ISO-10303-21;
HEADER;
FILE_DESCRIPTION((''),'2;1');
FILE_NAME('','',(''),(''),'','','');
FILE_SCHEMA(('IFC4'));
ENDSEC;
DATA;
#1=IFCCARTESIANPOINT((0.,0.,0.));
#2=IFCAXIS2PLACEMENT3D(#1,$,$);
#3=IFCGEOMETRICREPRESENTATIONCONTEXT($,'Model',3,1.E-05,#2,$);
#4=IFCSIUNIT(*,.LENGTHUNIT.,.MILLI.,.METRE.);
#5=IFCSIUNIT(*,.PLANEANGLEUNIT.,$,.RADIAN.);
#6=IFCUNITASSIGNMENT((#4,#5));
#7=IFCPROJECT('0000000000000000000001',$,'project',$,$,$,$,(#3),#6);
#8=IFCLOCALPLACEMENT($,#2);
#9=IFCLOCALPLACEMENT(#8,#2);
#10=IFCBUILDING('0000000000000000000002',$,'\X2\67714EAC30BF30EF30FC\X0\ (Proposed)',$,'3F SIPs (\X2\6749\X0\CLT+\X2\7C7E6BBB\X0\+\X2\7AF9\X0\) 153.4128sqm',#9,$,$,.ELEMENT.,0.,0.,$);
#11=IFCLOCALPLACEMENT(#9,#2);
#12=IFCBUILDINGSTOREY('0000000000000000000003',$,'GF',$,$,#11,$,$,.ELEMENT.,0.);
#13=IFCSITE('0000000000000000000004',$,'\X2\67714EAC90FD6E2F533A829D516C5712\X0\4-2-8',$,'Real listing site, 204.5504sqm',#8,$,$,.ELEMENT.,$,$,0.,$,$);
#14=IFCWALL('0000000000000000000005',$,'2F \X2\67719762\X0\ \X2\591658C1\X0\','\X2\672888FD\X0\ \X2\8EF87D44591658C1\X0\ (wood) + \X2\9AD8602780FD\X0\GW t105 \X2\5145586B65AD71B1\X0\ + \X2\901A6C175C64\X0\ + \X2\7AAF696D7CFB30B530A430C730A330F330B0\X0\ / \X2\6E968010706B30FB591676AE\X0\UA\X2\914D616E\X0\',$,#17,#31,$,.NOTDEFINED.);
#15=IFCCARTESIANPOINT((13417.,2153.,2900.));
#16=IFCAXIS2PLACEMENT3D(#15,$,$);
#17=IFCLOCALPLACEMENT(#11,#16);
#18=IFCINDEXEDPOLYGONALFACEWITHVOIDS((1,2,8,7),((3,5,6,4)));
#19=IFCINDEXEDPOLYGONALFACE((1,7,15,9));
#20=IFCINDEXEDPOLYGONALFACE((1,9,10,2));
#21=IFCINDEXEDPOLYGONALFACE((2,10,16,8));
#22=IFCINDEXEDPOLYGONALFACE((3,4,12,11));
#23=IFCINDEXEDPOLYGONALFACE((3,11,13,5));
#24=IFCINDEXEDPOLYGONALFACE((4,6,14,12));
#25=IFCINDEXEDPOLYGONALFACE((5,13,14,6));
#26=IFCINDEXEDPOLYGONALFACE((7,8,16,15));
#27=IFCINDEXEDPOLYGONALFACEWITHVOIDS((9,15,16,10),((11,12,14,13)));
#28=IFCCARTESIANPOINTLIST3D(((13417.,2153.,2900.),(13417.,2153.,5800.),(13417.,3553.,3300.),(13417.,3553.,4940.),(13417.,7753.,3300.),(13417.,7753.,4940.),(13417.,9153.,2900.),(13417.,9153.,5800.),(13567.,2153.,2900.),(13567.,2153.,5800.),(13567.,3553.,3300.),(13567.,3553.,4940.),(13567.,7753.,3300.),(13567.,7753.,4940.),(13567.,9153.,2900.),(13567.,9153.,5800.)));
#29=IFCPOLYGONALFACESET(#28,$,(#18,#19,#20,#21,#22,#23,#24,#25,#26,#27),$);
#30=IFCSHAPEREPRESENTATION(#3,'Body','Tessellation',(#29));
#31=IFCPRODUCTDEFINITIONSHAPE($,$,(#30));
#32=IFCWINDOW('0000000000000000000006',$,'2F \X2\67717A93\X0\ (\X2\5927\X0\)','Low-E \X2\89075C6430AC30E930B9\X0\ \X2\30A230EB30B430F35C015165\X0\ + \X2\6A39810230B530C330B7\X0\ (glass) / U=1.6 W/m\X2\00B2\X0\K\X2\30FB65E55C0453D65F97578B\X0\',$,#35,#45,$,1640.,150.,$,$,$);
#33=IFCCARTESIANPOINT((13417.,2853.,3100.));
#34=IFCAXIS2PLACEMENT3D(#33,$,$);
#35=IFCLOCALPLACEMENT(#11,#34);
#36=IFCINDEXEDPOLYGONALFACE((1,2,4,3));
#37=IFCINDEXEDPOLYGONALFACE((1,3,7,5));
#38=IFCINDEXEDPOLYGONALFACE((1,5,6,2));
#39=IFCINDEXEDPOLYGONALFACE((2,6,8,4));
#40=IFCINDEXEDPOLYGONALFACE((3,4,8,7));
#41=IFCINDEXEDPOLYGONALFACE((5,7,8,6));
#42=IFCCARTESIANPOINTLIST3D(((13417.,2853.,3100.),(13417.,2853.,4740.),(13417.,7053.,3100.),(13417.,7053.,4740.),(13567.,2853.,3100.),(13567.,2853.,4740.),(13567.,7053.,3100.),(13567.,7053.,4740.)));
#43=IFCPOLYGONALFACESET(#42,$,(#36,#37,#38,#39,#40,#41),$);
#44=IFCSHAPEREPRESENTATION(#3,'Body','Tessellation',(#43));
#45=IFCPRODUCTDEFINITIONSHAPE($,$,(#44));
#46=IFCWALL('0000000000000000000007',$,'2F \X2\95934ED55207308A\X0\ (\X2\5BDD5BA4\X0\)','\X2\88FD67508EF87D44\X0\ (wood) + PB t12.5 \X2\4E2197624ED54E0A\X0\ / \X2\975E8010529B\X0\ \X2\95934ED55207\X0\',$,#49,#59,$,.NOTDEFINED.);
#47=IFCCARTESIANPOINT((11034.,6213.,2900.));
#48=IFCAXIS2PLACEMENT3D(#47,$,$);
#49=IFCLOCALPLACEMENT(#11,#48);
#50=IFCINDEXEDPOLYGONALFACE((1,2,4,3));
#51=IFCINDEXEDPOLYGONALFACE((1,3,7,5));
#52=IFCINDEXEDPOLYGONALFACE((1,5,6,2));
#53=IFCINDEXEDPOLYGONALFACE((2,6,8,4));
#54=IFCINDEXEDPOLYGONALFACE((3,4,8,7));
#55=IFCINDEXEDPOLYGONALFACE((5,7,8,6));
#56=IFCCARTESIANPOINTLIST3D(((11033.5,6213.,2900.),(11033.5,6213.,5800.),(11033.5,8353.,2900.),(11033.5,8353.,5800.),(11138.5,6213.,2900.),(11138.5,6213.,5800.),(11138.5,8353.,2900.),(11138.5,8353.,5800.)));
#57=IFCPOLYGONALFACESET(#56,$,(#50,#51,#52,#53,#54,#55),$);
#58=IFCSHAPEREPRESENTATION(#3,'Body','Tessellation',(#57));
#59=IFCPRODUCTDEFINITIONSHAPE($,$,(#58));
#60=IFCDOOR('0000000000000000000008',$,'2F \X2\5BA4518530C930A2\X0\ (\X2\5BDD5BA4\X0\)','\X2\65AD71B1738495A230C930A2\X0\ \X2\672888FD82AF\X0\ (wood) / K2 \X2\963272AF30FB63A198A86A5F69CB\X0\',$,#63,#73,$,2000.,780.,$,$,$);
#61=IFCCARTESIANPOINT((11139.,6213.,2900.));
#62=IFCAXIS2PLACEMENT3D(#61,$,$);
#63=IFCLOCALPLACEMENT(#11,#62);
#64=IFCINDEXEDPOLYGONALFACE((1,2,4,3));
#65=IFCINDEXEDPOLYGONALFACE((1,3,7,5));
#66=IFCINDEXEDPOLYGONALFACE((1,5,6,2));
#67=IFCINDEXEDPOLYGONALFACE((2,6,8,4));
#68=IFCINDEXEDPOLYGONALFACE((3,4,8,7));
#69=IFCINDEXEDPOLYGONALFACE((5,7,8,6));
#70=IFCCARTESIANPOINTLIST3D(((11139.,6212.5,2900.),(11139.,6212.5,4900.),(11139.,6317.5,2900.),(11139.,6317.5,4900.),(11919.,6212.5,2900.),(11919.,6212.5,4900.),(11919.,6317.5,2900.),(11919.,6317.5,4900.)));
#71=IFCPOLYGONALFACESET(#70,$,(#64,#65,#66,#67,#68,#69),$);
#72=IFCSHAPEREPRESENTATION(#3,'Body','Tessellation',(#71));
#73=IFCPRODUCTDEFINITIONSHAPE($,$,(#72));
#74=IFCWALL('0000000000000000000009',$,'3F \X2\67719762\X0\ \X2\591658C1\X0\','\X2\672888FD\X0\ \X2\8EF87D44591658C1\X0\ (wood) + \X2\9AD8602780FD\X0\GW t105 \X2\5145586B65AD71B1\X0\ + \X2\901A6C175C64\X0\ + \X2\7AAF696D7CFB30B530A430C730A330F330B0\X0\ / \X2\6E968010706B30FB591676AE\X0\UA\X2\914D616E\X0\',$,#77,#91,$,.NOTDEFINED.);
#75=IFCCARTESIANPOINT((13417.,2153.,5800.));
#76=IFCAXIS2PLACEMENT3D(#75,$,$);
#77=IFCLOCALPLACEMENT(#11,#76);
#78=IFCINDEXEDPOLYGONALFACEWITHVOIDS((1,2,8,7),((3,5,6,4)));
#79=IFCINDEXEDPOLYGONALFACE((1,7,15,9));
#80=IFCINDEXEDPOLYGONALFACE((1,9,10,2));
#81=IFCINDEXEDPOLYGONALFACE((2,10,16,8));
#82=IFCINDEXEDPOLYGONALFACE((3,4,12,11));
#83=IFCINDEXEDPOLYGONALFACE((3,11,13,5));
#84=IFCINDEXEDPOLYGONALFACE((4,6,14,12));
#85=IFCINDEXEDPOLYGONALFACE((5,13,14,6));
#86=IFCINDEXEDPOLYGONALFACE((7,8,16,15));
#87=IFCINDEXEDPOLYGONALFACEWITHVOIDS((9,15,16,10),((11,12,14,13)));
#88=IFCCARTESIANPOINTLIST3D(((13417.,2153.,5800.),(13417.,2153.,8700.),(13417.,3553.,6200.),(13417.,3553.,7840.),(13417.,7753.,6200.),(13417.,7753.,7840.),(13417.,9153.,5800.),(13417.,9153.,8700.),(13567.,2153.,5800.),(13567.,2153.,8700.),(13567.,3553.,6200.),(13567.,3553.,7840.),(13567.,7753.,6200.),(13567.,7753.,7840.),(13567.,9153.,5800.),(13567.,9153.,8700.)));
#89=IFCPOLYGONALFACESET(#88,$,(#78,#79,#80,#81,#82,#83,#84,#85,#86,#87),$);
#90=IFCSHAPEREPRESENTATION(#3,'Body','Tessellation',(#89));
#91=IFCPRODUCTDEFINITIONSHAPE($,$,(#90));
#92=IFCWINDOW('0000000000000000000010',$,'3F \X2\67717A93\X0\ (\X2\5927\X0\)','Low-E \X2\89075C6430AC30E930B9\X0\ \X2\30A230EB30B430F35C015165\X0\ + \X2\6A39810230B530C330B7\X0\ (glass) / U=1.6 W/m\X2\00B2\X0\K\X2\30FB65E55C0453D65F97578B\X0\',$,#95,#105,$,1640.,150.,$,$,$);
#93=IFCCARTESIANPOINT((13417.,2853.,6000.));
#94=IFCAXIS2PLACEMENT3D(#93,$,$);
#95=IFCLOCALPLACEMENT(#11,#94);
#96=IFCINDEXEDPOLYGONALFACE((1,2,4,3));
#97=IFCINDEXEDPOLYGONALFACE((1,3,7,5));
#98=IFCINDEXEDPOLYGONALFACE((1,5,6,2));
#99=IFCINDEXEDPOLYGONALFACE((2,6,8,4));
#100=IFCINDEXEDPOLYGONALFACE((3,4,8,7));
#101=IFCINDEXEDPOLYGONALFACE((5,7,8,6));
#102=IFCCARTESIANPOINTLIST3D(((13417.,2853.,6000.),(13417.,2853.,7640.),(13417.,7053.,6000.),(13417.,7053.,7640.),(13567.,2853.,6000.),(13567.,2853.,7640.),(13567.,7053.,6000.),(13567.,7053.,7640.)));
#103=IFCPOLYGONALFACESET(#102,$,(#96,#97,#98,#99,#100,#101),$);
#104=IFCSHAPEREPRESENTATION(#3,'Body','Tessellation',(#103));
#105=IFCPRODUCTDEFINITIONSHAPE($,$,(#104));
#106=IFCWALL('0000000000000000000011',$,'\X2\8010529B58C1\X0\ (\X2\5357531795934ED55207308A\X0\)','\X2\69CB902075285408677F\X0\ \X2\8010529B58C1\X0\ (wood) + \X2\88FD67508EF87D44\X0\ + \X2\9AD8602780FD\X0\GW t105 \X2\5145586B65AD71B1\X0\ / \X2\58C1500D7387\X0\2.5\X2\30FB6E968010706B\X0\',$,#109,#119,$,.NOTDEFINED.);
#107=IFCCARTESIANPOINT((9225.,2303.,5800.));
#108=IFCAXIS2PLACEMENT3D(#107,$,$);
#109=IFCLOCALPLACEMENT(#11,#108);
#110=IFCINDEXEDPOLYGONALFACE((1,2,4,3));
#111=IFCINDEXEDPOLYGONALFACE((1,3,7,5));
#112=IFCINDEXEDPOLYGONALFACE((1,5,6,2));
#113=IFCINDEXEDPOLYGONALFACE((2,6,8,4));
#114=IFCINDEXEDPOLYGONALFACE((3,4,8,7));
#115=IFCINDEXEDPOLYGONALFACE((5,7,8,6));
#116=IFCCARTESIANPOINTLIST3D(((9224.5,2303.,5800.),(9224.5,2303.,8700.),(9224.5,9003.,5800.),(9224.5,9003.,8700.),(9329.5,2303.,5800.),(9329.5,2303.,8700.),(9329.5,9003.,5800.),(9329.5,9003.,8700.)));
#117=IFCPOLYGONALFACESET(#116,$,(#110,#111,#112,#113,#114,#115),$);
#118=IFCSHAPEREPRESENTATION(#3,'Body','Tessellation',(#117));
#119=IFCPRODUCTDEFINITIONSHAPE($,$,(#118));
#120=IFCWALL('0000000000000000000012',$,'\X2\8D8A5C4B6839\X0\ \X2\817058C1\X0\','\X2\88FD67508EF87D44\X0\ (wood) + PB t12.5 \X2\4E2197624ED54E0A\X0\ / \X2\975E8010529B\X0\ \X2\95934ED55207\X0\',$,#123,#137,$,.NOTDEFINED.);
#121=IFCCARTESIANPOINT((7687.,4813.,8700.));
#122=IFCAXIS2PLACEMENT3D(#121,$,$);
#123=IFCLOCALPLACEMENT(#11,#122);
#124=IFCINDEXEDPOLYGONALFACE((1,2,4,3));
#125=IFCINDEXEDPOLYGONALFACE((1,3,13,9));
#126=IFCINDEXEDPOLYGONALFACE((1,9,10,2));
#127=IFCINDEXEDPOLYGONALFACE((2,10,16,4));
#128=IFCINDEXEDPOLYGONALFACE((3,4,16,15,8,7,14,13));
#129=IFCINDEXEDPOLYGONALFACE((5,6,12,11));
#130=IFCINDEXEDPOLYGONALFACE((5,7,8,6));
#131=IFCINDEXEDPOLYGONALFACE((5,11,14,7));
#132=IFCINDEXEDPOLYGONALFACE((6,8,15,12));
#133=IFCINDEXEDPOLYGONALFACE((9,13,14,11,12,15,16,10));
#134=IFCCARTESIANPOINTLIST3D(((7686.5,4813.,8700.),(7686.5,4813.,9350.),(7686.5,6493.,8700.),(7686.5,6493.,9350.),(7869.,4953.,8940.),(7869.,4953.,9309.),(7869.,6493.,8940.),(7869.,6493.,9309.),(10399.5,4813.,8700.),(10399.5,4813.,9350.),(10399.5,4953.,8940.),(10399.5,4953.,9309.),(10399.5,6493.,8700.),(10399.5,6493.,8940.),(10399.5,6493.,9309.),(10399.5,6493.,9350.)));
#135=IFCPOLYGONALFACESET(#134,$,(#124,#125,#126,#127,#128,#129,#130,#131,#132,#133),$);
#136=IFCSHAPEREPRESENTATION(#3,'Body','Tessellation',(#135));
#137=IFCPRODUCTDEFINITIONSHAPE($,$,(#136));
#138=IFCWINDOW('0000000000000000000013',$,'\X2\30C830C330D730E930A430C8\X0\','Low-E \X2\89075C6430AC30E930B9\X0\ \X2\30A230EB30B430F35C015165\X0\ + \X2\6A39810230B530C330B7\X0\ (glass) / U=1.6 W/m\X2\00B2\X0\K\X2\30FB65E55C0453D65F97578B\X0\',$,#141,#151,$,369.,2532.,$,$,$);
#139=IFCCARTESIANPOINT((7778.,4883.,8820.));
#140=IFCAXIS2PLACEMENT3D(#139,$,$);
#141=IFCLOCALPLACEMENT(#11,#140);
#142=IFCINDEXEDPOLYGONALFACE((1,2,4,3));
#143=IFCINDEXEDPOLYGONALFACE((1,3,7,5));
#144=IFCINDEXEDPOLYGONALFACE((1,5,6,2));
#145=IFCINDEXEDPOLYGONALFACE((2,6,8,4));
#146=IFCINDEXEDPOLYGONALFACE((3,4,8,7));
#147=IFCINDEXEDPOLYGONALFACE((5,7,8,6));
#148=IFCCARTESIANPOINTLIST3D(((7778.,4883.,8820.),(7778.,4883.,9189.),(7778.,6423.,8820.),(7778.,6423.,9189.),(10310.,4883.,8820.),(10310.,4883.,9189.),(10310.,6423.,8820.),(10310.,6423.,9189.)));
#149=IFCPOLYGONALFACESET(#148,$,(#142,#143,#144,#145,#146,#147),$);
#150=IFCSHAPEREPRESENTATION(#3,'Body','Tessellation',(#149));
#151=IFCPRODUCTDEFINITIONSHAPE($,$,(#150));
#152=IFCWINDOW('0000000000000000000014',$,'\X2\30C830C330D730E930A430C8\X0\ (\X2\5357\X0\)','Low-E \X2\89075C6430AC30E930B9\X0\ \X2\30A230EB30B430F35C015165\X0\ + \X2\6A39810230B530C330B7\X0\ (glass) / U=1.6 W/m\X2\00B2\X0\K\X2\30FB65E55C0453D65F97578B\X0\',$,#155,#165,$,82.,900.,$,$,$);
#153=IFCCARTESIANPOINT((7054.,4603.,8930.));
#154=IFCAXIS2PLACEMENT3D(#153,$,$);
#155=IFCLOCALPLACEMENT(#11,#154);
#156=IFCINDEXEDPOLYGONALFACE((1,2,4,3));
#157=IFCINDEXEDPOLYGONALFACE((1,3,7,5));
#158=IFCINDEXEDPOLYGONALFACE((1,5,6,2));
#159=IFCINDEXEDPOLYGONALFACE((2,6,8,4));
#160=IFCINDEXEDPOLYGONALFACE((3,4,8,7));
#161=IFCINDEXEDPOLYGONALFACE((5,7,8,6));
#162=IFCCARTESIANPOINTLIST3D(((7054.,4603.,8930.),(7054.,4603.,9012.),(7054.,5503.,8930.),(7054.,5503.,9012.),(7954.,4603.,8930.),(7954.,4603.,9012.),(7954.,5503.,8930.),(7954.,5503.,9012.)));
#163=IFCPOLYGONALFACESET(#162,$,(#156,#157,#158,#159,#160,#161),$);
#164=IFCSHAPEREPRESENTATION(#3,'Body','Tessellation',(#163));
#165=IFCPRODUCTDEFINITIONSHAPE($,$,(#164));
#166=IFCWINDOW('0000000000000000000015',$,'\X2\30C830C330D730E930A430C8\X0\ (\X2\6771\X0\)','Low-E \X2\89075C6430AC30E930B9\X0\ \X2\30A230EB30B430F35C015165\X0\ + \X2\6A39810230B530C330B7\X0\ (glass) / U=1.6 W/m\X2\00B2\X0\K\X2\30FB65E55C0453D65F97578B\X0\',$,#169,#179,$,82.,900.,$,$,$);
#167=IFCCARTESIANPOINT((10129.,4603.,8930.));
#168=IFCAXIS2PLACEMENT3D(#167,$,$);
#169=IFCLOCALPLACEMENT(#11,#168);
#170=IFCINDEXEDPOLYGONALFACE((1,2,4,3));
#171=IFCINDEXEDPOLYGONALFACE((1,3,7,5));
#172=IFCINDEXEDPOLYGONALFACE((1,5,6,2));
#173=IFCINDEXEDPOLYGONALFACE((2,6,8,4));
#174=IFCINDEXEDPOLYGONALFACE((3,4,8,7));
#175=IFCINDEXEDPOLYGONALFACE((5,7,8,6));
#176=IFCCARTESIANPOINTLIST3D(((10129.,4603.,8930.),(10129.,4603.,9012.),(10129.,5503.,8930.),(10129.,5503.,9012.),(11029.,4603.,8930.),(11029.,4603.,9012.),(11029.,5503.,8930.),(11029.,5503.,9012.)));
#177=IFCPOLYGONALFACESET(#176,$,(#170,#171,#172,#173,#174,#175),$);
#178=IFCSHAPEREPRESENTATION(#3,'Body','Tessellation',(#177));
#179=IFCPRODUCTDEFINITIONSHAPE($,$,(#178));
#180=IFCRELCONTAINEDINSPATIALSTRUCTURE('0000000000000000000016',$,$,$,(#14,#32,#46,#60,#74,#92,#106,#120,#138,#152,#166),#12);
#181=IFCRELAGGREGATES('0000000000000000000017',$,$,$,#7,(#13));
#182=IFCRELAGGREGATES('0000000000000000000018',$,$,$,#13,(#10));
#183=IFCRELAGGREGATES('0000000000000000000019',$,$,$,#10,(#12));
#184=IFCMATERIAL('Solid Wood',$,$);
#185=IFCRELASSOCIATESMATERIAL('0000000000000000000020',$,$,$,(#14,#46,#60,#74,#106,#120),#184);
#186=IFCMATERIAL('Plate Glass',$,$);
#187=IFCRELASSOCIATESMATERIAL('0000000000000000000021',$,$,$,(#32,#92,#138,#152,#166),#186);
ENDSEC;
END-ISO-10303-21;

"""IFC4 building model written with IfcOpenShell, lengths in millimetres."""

from ifc_helpers import new_model, si_unit, frame, frame_2d, origin, place, context, project, spatial, rectangle, extrude, material, element, fill, save


model = new_model("IFC4")

# Units and contexts
model_context = context("Model", 3, precision=1e-05, world=origin())
ifc_project = project(units=[si_unit("LENGTHUNIT", "METRE", prefix="MILLI"), si_unit("PLANEANGLEUNIT", "RADIAN")], contexts=[model_context])

# Site, building, storey
site_placement = place(None, origin())
site = spatial("IfcSite", under=ifc_project, at=site_placement, Name="東京都港区芝公園4-2-8", ObjectType="Real listing site, 204.5504sqm", CompositionType="ELEMENT", RefElevation=0.0)
building_placement = place(site_placement, origin())
building = spatial("IfcBuilding", under=site, at=building_placement, Name="東京タワー (Proposed)", ObjectType="3F SIPs (杉CLT+籾殻+竹) 153.4128sqm", CompositionType="ELEMENT", ElevationOfRefHeight=0.0, ElevationOfTerrain=0.0)
storey_placement = place(building_placement, origin())
storey = spatial("IfcBuildingStorey", under=building, at=storey_placement, Name="GF", CompositionType="ELEMENT", Elevation=0.0)

# Wall, opening, window
ifc_material_1 = material(Name="Solid Wood")
wall_1_placement = place(storey_placement, frame((13417.0, 2153.0, 2900.0)))
wall_1 = element("IfcWall", 1, at=wall_1_placement, inside=storey, material=ifc_material_1, Name="2F 東面 外壁", Description="木製 軸組外壁 (wood) + 高性能GW t105 充填断熱 + 通気層 + 窯業系サイディング / 準耐火・外皮UA配慮", PredefinedType="NOTDEFINED", context=model_context, shape_type="SweptSolid", body=[
    extrude(rectangle(XDim=150.0, YDim=7000.0, at=frame_2d((75.0, 3500.0))), frame((13417.0, 2153.0, 2900.0)), (0.0, 0.0, 1.0), 2900.0),
])
opening_1_placement = place(storey_placement, frame((13417.0, 2853.0, 3100.0)))
opening_1 = element("IfcOpeningElement", 2, at=opening_1_placement, cuts=wall_1, PredefinedType="NOTDEFINED", context=model_context, shape_type="SweptSolid", body=[
    extrude(rectangle(XDim=150.0, YDim=4200.0, at=frame_2d((75.0, 2100.0))), frame((13417.0, 2853.0, 3100.0)), (0.0, 0.0, 1.0), 1640.0),
])
ifc_material_2 = material(Name="Plate Glass")
window_1_placement = place(storey_placement, frame((13417.0, 2853.0, 3100.0)))
window_1 = element("IfcWindow", 3, at=window_1_placement, inside=storey, material=ifc_material_2, Name="2F 東窓 (大)", Description="Low-E 複層ガラス アルゴン封入 + 樹脂サッシ (glass) / U=1.6 W/m²K・日射取得型", OverallHeight=1640.0, OverallWidth=150.0, context=model_context, shape_type="SweptSolid", body=[
    extrude(rectangle(XDim=150.0, YDim=4200.0, at=frame_2d((75.0, 2100.0))), frame((13417.0, 2853.0, 3100.0)), (0.0, 0.0, 1.0), 1640.0),
])
fill(opening_1, window_1)

# Wall
wall_2_placement = place(storey_placement, frame((11034.0, 6213.0, 2900.0)))
element("IfcWall", 4, at=wall_2_placement, inside=storey, material=ifc_material_1, Name="2F 間仕切り (寝室)", Description="製材軸組 (wood) + PB t12.5 両面仕上 / 非耐力 間仕切", PredefinedType="NOTDEFINED", context=model_context, shape_type="SweptSolid", body=[
    extrude(rectangle(XDim=105.0, YDim=2140.0, at=frame_2d((52.0, 1070.0))), frame((11034.0, 6213.0, 2900.0)), (0.0, 0.0, 1.0), 2900.0),
])

# Door
door_1_placement = place(storey_placement, frame((11139.0, 6213.0, 2900.0)))
element("IfcDoor", 5, at=door_1_placement, inside=storey, material=ifc_material_1, Name="2F 室内ドア (寝室)", Description="断熱玄関ドア 木製芯 (wood) / K2 防犯・採風機構", OverallHeight=2000.0, OverallWidth=780.0, context=model_context, shape_type="SweptSolid", body=[
    extrude(rectangle(XDim=780.0, YDim=105.0, at=frame_2d((390.0, 52.0))), frame((11139.0, 6213.0, 2900.0)), (0.0, 0.0, 1.0), 2000.0),
])

# Wall, opening, window
wall_3_placement = place(storey_placement, frame((13417.0, 2153.0, 5800.0)))
wall_3 = element("IfcWall", 6, at=wall_3_placement, inside=storey, material=ifc_material_1, Name="3F 東面 外壁", Description="木製 軸組外壁 (wood) + 高性能GW t105 充填断熱 + 通気層 + 窯業系サイディング / 準耐火・外皮UA配慮", PredefinedType="NOTDEFINED", context=model_context, shape_type="SweptSolid", body=[
    extrude(rectangle(XDim=150.0, YDim=7000.0, at=frame_2d((75.0, 3500.0))), frame((13417.0, 2153.0, 5800.0)), (0.0, 0.0, 1.0), 2900.0),
])
opening_2_placement = place(storey_placement, frame((13417.0, 2853.0, 6000.0)))
opening_2 = element("IfcOpeningElement", 7, at=opening_2_placement, cuts=wall_3, PredefinedType="NOTDEFINED", context=model_context, shape_type="SweptSolid", body=[
    extrude(rectangle(XDim=150.0, YDim=4200.0, at=frame_2d((75.0, 2100.0))), frame((13417.0, 2853.0, 6000.0)), (0.0, 0.0, 1.0), 1640.0),
])
window_2_placement = place(storey_placement, frame((13417.0, 2853.0, 6000.0)))
window_2 = element("IfcWindow", 8, at=window_2_placement, inside=storey, material=ifc_material_2, Name="3F 東窓 (大)", Description="Low-E 複層ガラス アルゴン封入 + 樹脂サッシ (glass) / U=1.6 W/m²K・日射取得型", OverallHeight=1640.0, OverallWidth=150.0, context=model_context, shape_type="SweptSolid", body=[
    extrude(rectangle(XDim=150.0, YDim=4200.0, at=frame_2d((75.0, 2100.0))), frame((13417.0, 2853.0, 6000.0)), (0.0, 0.0, 1.0), 1640.0),
])
fill(opening_2, window_2)

# Wall
wall_4_placement = place(storey_placement, frame((9225.0, 2303.0, 5800.0)))
element("IfcWall", 9, at=wall_4_placement, inside=storey, material=ifc_material_1, Name="耐力壁 (南北間仕切り)", Description="構造用合板 耐力壁 (wood) + 製材軸組 + 高性能GW t105 充填断熱 / 壁倍率2.5・準耐火", PredefinedType="NOTDEFINED", context=model_context, shape_type="SweptSolid", body=[
    extrude(rectangle(XDim=105.0, YDim=6700.0, at=frame_2d((52.0, 3350.0))), frame((9225.0, 2303.0, 5800.0)), (0.0, 0.0, 1.0), 2900.0),
])

# Wall, openings, windows
wall_5_placement = place(storey_placement, frame((7687.0, 4813.0, 8700.0)))
wall_5 = element("IfcWall", 10, at=wall_5_placement, inside=storey, material=ifc_material_1, Name="越屋根 腰壁", Description="製材軸組 (wood) + PB t12.5 両面仕上 / 非耐力 間仕切", PredefinedType="NOTDEFINED", context=model_context, shape_type="SweptSolid", body=[
    extrude(rectangle(XDim=2713.0, YDim=1680.0, at=frame_2d((1356.0, 840.0))), frame((7687.0, 4813.0, 8700.0)), (0.0, 0.0, 1.0), 650.0),
])
opening_3_placement = place(storey_placement, frame((7778.0, 4883.0, 8820.0)))
opening_3 = element("IfcOpeningElement", 11, at=opening_3_placement, cuts=wall_5, PredefinedType="NOTDEFINED", context=model_context, shape_type="SweptSolid", body=[
    extrude(rectangle(XDim=2532.0, YDim=1540.0, at=frame_2d((1266.0, 770.0))), frame((7778.0, 4883.0, 8820.0)), (0.0, 0.0, 1.0), 369.0),
])
opening_4_placement = place(storey_placement, frame((7054.0, 4603.0, 8930.0)))
opening_4 = element("IfcOpeningElement", 12, at=opening_4_placement, cuts=wall_5, PredefinedType="NOTDEFINED", context=model_context, shape_type="SweptSolid", body=[
    extrude(rectangle(XDim=900.0, YDim=900.0, at=frame_2d((450.0, 450.0))), frame((7054.0, 4603.0, 8930.0)), (0.0, 0.0, 1.0), 82.0),
])
opening_5_placement = place(storey_placement, frame((10129.0, 4603.0, 8930.0)))
opening_5 = element("IfcOpeningElement", 13, at=opening_5_placement, cuts=wall_5, PredefinedType="NOTDEFINED", context=model_context, shape_type="SweptSolid", body=[
    extrude(rectangle(XDim=900.0, YDim=900.0, at=frame_2d((450.0, 450.0))), frame((10129.0, 4603.0, 8930.0)), (0.0, 0.0, 1.0), 82.0),
])
window_3_placement = place(storey_placement, frame((7778.0, 4883.0, 8820.0)))
window_3 = element("IfcWindow", 14, at=window_3_placement, inside=storey, material=ifc_material_2, Name="トップライト", Description="Low-E 複層ガラス アルゴン封入 + 樹脂サッシ (glass) / U=1.6 W/m²K・日射取得型", OverallHeight=369.0, OverallWidth=2532.0, context=model_context, shape_type="SweptSolid", body=[
    extrude(rectangle(XDim=2532.0, YDim=1540.0, at=frame_2d((1266.0, 770.0))), frame((7778.0, 4883.0, 8820.0)), (0.0, 0.0, 1.0), 369.0),
])
fill(opening_3, window_3)
window_4_placement = place(storey_placement, frame((7054.0, 4603.0, 8930.0)))
window_4 = element("IfcWindow", 15, at=window_4_placement, inside=storey, material=ifc_material_2, Name="トップライト (南)", Description="Low-E 複層ガラス アルゴン封入 + 樹脂サッシ (glass) / U=1.6 W/m²K・日射取得型", OverallHeight=82.0, OverallWidth=900.0, context=model_context, shape_type="SweptSolid", body=[
    extrude(rectangle(XDim=900.0, YDim=900.0, at=frame_2d((450.0, 450.0))), frame((7054.0, 4603.0, 8930.0)), (0.0, 0.0, 1.0), 82.0),
])
fill(opening_4, window_4)
window_5_placement = place(storey_placement, frame((10129.0, 4603.0, 8930.0)))
window_5 = element("IfcWindow", 16, at=window_5_placement, inside=storey, material=ifc_material_2, Name="トップライト (東)", Description="Low-E 複層ガラス アルゴン封入 + 樹脂サッシ (glass) / U=1.6 W/m²K・日射取得型", OverallHeight=82.0, OverallWidth=900.0, context=model_context, shape_type="SweptSolid", body=[
    extrude(rectangle(XDim=900.0, YDim=900.0, at=frame_2d((450.0, 450.0))), frame((10129.0, 4603.0, 8930.0)), (0.0, 0.0, 1.0), 82.0),
])
fill(opening_5, window_5)

save(model, "model.ifc")
